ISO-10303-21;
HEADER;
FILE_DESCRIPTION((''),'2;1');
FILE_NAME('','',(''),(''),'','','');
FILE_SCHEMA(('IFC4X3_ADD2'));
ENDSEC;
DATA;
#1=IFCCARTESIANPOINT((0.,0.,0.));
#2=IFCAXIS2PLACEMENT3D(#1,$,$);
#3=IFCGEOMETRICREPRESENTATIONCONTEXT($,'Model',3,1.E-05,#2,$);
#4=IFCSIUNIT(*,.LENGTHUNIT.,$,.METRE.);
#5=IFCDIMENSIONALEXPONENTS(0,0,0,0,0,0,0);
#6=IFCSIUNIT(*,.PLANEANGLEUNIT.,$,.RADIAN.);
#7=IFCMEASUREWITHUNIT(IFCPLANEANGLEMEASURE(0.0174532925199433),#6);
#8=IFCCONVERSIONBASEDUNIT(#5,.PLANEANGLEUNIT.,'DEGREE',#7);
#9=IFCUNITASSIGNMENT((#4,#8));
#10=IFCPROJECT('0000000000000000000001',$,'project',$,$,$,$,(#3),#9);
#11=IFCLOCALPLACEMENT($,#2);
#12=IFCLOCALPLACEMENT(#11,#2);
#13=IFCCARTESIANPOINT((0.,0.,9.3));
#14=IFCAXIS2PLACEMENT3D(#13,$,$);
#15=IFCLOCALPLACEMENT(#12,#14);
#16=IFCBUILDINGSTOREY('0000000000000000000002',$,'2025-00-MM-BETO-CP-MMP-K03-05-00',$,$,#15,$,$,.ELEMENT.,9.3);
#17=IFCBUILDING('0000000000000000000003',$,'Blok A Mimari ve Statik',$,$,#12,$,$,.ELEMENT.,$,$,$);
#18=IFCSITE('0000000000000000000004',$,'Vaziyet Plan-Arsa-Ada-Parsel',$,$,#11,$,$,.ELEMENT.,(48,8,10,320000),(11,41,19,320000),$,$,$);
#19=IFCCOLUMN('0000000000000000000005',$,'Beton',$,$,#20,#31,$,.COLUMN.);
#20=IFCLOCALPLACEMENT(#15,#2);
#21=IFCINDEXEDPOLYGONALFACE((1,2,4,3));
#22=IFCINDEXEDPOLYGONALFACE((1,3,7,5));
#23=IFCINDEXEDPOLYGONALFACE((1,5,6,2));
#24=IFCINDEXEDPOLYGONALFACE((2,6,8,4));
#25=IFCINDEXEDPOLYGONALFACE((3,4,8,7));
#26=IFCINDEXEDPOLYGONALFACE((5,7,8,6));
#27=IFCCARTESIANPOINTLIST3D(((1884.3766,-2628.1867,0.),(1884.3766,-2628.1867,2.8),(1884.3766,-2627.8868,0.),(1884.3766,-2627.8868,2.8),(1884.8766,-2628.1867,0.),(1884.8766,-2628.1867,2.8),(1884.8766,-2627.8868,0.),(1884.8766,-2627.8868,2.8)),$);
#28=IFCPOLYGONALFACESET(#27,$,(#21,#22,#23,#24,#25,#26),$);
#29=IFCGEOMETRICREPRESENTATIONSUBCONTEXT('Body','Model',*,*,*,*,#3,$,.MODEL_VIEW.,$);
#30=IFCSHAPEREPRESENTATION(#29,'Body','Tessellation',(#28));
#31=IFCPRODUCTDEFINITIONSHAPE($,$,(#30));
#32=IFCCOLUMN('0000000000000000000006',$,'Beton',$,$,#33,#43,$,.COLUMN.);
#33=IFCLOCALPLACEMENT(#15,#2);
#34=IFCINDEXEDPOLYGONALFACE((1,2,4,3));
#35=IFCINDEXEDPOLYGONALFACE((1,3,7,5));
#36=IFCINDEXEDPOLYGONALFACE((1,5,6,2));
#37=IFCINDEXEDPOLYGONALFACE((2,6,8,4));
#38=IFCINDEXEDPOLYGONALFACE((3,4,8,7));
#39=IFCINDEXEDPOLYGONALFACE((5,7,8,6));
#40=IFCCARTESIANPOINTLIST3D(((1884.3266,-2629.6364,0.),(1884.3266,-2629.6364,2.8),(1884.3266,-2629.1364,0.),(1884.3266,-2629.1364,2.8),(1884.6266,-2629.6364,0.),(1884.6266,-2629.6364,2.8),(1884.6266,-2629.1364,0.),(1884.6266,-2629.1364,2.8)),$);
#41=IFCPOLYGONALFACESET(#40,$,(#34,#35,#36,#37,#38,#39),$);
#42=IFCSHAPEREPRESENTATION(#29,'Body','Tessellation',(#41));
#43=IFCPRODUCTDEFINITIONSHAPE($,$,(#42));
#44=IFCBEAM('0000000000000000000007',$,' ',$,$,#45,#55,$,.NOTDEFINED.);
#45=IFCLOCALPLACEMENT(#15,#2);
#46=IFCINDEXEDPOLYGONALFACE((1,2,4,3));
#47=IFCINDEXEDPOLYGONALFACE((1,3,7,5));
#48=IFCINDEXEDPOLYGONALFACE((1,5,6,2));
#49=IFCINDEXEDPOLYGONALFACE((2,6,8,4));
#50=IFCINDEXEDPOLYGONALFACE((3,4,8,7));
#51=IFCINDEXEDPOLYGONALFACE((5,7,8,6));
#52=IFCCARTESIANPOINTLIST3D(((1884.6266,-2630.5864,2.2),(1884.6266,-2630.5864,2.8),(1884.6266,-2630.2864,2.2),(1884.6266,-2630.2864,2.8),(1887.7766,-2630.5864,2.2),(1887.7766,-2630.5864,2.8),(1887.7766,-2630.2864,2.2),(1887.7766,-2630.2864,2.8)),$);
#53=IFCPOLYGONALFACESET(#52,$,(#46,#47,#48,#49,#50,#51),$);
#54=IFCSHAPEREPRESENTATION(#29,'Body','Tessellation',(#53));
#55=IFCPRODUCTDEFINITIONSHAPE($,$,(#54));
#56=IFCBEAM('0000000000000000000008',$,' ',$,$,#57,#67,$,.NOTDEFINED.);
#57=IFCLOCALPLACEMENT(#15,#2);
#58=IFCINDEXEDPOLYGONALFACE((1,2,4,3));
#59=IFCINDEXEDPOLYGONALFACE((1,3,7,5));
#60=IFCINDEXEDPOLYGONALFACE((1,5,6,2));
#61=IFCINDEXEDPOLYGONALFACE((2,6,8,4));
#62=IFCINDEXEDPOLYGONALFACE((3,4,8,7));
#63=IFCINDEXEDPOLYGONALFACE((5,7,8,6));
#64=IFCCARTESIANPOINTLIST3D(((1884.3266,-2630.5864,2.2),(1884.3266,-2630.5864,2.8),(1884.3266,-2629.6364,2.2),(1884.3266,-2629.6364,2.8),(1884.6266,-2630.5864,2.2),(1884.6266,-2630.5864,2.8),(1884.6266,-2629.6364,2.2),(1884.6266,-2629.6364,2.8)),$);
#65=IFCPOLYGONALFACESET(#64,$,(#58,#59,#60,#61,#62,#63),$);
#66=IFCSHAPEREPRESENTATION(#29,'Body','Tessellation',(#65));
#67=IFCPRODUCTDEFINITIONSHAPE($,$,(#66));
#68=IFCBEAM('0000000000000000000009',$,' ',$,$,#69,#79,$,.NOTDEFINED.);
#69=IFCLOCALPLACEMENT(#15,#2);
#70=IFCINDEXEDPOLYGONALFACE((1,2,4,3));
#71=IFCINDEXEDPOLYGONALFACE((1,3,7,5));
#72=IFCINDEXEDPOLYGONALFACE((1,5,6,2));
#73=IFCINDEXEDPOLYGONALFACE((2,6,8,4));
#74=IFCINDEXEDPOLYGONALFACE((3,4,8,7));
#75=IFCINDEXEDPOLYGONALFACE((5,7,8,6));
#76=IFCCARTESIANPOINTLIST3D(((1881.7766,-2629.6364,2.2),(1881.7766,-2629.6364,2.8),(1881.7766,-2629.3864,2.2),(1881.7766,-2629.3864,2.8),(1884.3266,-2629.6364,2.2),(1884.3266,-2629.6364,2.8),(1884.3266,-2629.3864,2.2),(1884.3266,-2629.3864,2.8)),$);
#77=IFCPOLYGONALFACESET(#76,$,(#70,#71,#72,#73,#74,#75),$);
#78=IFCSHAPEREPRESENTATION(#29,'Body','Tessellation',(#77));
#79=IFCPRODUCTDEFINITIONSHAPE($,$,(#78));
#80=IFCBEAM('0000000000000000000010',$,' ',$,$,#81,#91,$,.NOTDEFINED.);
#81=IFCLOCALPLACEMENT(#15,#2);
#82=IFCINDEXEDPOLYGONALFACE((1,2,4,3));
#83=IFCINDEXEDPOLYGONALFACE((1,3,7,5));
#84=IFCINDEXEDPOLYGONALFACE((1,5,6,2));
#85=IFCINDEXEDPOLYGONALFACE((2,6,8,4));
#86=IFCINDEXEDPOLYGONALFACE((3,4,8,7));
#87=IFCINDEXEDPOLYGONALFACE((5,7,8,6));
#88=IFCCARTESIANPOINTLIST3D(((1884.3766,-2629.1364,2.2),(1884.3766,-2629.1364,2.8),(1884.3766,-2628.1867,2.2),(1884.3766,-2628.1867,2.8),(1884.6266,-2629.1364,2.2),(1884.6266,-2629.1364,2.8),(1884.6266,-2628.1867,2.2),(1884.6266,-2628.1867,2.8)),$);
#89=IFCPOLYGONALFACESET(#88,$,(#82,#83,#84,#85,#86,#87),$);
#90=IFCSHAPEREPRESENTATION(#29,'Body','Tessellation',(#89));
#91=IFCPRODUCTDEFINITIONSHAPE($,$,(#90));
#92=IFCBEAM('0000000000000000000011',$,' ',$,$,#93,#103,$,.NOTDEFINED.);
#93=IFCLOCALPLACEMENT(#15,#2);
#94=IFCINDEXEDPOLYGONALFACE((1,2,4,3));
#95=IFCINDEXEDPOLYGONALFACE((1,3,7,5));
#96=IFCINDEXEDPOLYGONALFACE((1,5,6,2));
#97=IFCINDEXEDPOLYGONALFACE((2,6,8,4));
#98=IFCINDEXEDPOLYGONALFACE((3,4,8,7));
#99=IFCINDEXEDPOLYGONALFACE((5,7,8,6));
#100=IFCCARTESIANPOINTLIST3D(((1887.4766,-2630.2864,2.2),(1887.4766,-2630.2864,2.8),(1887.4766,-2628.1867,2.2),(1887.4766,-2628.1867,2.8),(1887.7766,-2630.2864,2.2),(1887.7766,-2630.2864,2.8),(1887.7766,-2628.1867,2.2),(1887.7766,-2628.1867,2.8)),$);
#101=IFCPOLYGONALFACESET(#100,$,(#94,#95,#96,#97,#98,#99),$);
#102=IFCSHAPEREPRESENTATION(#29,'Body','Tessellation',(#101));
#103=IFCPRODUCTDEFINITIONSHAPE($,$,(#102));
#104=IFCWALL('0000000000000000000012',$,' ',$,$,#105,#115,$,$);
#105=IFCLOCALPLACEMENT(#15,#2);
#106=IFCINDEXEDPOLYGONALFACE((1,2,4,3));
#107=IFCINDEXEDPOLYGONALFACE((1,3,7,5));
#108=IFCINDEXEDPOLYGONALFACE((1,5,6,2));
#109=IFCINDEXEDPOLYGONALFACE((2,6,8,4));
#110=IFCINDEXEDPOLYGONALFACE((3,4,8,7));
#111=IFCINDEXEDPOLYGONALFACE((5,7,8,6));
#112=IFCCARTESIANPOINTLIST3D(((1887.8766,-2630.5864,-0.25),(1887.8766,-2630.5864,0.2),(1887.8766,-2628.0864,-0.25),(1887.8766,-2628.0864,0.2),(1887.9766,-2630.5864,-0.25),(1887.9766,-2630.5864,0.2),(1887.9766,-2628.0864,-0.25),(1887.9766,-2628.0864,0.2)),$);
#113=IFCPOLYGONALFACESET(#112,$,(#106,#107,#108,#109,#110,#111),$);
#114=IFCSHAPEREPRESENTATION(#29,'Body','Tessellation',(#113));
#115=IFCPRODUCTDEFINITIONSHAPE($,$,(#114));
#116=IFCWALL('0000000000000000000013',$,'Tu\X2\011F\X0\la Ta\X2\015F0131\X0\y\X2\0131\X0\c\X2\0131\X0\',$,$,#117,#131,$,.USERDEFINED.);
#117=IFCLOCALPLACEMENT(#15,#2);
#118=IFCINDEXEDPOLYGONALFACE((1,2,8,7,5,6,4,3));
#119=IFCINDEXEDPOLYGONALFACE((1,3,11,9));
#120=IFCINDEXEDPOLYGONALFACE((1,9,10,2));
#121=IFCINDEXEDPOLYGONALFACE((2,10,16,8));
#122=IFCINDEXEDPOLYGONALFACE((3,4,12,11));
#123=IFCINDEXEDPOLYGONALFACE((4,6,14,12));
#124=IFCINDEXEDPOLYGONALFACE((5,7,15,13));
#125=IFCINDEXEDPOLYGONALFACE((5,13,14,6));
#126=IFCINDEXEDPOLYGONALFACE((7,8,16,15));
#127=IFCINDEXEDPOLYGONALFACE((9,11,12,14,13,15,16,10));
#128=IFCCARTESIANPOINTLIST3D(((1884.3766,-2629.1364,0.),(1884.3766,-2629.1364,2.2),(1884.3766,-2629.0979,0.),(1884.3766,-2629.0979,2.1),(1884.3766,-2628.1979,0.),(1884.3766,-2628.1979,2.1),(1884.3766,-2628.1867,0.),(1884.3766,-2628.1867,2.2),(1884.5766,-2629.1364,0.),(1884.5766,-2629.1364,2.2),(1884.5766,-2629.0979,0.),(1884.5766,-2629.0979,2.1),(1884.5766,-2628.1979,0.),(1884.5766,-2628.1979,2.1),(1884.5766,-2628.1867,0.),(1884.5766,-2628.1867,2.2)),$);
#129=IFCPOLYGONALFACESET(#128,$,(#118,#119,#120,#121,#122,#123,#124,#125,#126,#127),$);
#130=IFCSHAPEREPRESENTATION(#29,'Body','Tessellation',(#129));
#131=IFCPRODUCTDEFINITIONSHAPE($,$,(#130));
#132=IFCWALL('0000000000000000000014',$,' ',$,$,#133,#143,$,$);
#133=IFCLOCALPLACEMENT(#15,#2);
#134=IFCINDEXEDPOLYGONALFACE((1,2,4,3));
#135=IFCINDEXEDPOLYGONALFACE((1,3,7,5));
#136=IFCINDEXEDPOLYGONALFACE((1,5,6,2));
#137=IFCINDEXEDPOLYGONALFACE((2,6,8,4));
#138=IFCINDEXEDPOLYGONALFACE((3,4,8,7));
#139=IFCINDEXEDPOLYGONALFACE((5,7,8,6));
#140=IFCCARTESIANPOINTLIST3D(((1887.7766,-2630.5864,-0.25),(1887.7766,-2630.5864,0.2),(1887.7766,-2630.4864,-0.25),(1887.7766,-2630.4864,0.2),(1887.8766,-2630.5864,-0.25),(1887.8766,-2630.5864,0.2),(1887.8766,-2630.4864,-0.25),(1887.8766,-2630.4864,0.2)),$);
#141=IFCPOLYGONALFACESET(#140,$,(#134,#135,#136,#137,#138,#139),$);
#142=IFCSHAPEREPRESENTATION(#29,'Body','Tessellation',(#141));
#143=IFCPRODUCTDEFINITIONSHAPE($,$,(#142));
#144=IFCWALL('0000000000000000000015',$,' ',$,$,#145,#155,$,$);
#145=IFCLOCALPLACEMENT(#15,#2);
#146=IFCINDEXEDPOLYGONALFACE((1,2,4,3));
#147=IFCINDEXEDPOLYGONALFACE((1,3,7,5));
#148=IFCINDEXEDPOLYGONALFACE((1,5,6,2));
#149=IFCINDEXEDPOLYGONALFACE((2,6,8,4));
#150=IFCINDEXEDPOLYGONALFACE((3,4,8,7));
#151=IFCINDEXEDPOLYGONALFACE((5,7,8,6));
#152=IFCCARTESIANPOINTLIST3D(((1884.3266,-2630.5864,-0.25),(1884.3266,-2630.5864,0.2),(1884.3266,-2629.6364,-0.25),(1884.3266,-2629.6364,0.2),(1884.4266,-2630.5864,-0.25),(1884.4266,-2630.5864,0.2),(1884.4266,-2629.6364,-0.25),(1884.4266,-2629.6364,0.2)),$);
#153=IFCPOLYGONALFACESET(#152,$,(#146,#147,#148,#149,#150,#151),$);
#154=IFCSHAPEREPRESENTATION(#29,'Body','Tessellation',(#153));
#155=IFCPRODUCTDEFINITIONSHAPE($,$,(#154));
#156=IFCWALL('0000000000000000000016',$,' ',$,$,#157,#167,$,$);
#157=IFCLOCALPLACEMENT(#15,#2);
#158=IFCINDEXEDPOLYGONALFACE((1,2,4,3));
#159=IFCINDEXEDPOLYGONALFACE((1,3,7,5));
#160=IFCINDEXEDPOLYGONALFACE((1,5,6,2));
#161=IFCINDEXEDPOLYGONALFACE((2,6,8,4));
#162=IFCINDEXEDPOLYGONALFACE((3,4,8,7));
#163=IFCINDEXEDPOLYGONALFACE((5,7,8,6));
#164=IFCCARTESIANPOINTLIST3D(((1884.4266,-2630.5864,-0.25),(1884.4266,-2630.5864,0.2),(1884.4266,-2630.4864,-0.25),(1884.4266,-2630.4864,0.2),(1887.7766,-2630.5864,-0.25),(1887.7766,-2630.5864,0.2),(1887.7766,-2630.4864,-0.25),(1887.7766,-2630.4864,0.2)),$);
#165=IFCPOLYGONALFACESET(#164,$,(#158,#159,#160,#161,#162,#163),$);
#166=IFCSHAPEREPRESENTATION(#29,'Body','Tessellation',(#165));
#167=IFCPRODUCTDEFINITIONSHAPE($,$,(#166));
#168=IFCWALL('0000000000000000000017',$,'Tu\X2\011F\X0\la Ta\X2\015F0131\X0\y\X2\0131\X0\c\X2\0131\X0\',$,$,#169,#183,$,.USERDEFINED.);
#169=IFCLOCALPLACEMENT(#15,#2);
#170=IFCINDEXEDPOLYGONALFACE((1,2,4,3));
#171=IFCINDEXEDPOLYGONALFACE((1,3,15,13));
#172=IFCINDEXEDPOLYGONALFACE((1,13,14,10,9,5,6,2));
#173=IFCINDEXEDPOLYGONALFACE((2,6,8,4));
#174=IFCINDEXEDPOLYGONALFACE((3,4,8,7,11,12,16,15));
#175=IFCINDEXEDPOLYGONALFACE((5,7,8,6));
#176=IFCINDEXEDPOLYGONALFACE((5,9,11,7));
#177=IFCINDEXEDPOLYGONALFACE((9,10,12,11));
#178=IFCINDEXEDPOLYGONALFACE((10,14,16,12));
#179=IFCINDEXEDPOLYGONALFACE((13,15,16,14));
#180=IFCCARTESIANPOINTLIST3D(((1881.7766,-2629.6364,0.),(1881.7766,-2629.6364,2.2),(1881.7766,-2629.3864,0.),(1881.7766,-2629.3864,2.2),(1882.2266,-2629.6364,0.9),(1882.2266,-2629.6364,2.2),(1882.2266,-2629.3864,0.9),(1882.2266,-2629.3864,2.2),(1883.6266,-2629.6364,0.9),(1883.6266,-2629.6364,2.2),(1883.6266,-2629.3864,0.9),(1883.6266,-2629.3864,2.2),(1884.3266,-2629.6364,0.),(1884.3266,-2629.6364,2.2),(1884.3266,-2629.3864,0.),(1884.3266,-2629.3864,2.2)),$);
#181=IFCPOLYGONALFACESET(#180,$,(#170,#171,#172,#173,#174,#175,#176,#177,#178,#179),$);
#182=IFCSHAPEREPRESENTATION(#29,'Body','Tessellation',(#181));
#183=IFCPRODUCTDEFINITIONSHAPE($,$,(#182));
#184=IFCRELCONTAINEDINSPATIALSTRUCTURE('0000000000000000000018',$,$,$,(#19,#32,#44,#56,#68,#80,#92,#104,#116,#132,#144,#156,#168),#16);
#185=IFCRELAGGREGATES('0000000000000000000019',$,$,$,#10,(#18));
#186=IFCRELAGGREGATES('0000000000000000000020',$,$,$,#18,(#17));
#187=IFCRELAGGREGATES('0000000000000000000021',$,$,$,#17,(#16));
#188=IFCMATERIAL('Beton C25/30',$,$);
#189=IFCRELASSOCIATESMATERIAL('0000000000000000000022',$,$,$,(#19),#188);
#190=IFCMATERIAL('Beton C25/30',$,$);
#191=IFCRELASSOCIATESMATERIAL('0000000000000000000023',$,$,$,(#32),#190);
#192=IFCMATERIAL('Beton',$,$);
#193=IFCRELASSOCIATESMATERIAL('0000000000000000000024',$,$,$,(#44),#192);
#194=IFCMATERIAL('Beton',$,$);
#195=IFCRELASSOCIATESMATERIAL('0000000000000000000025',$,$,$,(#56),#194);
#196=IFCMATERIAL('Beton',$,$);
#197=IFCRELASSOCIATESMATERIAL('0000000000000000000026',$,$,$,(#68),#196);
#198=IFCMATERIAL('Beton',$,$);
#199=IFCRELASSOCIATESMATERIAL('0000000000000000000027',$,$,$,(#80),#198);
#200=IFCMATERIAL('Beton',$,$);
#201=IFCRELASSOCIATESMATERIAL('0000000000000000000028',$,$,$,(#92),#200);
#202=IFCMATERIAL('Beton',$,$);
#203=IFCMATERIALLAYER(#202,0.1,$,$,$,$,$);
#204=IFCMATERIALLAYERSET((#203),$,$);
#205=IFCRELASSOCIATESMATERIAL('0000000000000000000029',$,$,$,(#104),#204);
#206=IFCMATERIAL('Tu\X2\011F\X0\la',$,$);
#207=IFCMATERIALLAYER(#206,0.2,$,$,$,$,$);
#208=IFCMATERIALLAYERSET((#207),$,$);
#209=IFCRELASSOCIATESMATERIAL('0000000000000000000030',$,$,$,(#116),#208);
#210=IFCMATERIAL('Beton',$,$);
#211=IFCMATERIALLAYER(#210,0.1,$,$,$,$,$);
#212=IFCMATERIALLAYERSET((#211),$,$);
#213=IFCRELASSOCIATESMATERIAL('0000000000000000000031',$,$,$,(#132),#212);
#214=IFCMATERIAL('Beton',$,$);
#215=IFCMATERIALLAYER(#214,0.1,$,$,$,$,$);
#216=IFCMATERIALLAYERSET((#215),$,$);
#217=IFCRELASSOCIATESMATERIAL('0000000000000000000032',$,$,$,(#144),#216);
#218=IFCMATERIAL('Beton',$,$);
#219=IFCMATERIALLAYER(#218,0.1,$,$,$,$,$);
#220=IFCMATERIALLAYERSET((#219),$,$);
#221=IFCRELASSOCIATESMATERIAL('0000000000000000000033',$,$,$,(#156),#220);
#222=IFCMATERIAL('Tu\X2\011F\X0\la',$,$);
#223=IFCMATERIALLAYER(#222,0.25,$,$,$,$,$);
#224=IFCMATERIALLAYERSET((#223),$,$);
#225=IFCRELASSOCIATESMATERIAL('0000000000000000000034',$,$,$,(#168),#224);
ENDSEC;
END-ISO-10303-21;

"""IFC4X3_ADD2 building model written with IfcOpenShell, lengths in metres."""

from ifc_helpers import new_model, entity, si_unit, converted_unit, frame, frame_2d, origin, origin_with_axes, place, context, subcontext, project, spatial, polyline, rectangle, outline, extrude, material, layer, layer_set, layer_usage, element, save


model = new_model("IFC4X3_ADD2")

# Units and contexts
model_context = context("Model", 3, precision=1e-05, world=origin())
body_context = subcontext(model_context, "Body", "Model", "MODEL_VIEW")
ifc_project = project(units=[si_unit("LENGTHUNIT", "METRE"), converted_unit("PLANEANGLEUNIT", "DEGREE", entity("IfcPlaneAngleMeasure", 0.0174532925199433), si_unit("PLANEANGLEUNIT", "RADIAN"), dimensions=[0, 0, 0, 0, 0, 0, 0])], contexts=[model_context])

# Site, building, storey
site_placement = place(None, origin())
site = spatial("IfcSite", under=ifc_project, at=site_placement, Name="Vaziyet Plan-Arsa-Ada-Parsel", CompositionType="ELEMENT", RefLatitude=(48, 8, 10, 320000), RefLongitude=(11, 41, 19, 320000))
building_placement = place(site_placement, origin())
building = spatial("IfcBuilding", under=site, at=building_placement, Name="Blok A Mimari ve Statik", CompositionType="ELEMENT")
storey_placement = place(building_placement, frame((0.0, 0.0, 9.3)))
storey = spatial("IfcBuildingStorey", under=building, at=storey_placement, Name="2025-00-MM-BETO-CP-MMP-K03-05-00", CompositionType="ELEMENT", Elevation=9.3)

# Columns
ifc_material_1 = material(Name="Beton C25/30")
column_1_placement = place(storey_placement, frame((1884.3766, -2628.1867, 0.0)))
element("IfcColumn", 1, at=column_1_placement, inside=storey, material=ifc_material_1, Name="Beton", PredefinedType="COLUMN", context=body_context, shape_type="SweptSolid", body=[
    extrude(outline(polyline([(0.0, 0.3), (0.0, 0.0), (0.5, 0.0), (0.5, 0.3), (0.0, 0.3)])), origin_with_axes(), (0.0, 0.0, 1.0), 2.8),
])
ifc_material_2 = material(Name="Beton C25/30")
column_2_placement = place(storey_placement, frame((1884.3266, -2629.6364, 0.0)))
element("IfcColumn", 2, at=column_2_placement, inside=storey, material=ifc_material_2, Name="Beton", PredefinedType="COLUMN", context=body_context, shape_type="SweptSolid", body=[
    extrude(outline(polyline([(0.0, 0.5), (0.0, 0.0), (0.3, 0.0), (0.3, 0.5), (0.0, 0.5)])), origin_with_axes(), (0.0, 0.0, 1.0), 2.8),
])

# Beams
ifc_material_3 = material(Name="Beton")
beam_1_placement = place(storey_placement, frame((1884.6266, -2630.5864, 2.2)))
element("IfcBeam", 3, at=beam_1_placement, inside=storey, material=ifc_material_3, Name=" ", PredefinedType="NOTDEFINED", context=body_context, shape_type="SweptSolid", body=[
    extrude(rectangle(XDim=0.3, YDim=0.6, at=frame_2d((0.15, 0.3), x_axis=(1.0, 0.0))), frame((0.0, 0.0, 0.0), z_axis=(1.0, 0.0, 0.0), x_axis=(0.0, 1.0, 0.0)), (0.0, 0.0, 1.0), 3.15),
])
ifc_material_4 = material(Name="Beton")
beam_2_placement = place(storey_placement, frame((1884.3266, -2629.6364, 2.2), z_axis=(0.0, 0.0, 1.0), x_axis=(0.0, -1.0, 0.0)))
element("IfcBeam", 4, at=beam_2_placement, inside=storey, material=ifc_material_4, Name=" ", PredefinedType="NOTDEFINED", context=body_context, shape_type="SweptSolid", body=[
    extrude(rectangle(XDim=0.3, YDim=0.6, at=frame_2d((0.15, 0.3), x_axis=(1.0, 0.0))), frame((0.0, 0.0, 0.0), z_axis=(1.0, 0.0, 0.0), x_axis=(0.0, 1.0, 0.0)), (0.0, 0.0, 1.0), 0.95),
])
ifc_material_5 = material(Name="Beton")
beam_3_placement = place(storey_placement, frame((1881.7766, -2629.6364, 2.2), z_axis=(0.0, 0.0, 1.0), x_axis=(1.0, 0.0, 0.0)))
element("IfcBeam", 5, at=beam_3_placement, inside=storey, material=ifc_material_5, Name=" ", PredefinedType="NOTDEFINED", context=body_context, shape_type="SweptSolid", body=[
    extrude(rectangle(XDim=0.25, YDim=0.6, at=frame_2d((0.125, 0.3), x_axis=(1.0, 0.0))), frame((0.0, 0.0, 0.0), z_axis=(1.0, 0.0, 0.0), x_axis=(0.0, 1.0, 0.0)), (0.0, 0.0, 1.0), 2.55),
])
ifc_material_6 = material(Name="Beton")
beam_4_placement = place(storey_placement, frame((1884.6266, -2629.1364, 2.2), z_axis=(0.0, 0.0, 1.0), x_axis=(0.000003, 1.0, 0.0)))
element("IfcBeam", 6, at=beam_4_placement, inside=storey, material=ifc_material_6, Name=" ", PredefinedType="NOTDEFINED", context=body_context, shape_type="SweptSolid", body=[
    extrude(rectangle(XDim=0.25, YDim=0.6, at=frame_2d((0.125, 0.3), x_axis=(1.0, 0.0))), frame((0.0, 0.0, 0.0), z_axis=(1.0, 0.0, 0.0), x_axis=(0.0, 1.0, 0.0)), (0.0, 0.0, 1.0), 0.9497),
])
ifc_material_7 = material(Name="Beton")
beam_5_placement = place(storey_placement, frame((1887.7766, -2630.2864, 2.2), z_axis=(0.0, 0.0, 1.0), x_axis=(0.0, 1.0, 0.0)))
element("IfcBeam", 7, at=beam_5_placement, inside=storey, material=ifc_material_7, Name=" ", PredefinedType="NOTDEFINED", context=body_context, shape_type="SweptSolid", body=[
    extrude(rectangle(XDim=0.3, YDim=0.6, at=frame_2d((0.15, 0.3), x_axis=(1.0, 0.0))), frame((0.0, 0.0, 0.0), z_axis=(1.0, 0.0, 0.0), x_axis=(0.0, 1.0, 0.0)), (0.0, 0.0, 1.0), 2.0997),
])

# Wall
ifc_material_8 = material(Name="Beton")
ifc_layer_1 = layer(ifc_material_8, 0.1)
ifc_layer_set_1 = layer_set([ifc_layer_1])
ifc_layer_usage_1 = layer_usage(ifc_layer_set_1, "AXIS2", "POSITIVE", 0.0)
wall_1_placement = place(storey_placement, frame((1887.9766, -2630.5864, -0.25), z_axis=(0.0, 0.0, 1.0), x_axis=(0.0, 1.0, 0.0)))
element("IfcWall", 8, at=wall_1_placement, inside=storey, material=ifc_layer_usage_1, Name=" ", context=body_context, shape_type="SweptSolid", body=[
    extrude(rectangle(XDim=2.5, YDim=0.1, at=frame_2d((1.25, 0.05), x_axis=(1.0, 0.0))), origin_with_axes(), (0.0, 0.0, 1.0), 0.45),
])

# Wall, opening
ifc_material_9 = material(Name="Tuğla")
ifc_layer_2 = layer(ifc_material_9, 0.2)
ifc_layer_set_2 = layer_set([ifc_layer_2])
ifc_layer_usage_2 = layer_usage(ifc_layer_set_2, "AXIS2", "POSITIVE", 0.0)
wall_2_placement = place(storey_placement, frame((1884.3766, -2628.1867, 0.0), z_axis=(0.0, 0.0, 1.0), x_axis=(0.0, -1.0, 0.0)))
wall_2 = element("IfcWall", 9, at=wall_2_placement, inside=storey, material=ifc_layer_usage_2, Name="Tuğla Taşıyıcı", PredefinedType="USERDEFINED", context=body_context, shape_type="SweptSolid", body=[
    extrude(rectangle(XDim=0.9497, YDim=0.2, at=frame_2d((0.4748, 0.1), x_axis=(1.0, 0.0))), origin_with_axes(), (0.0, 0.0, 1.0), 2.2),
])
opening_1_placement = place(wall_2_placement, frame((0.0111, 0.0, 0.0), z_axis=(0.0, 1.0, 0.0), x_axis=(0.0, 0.0, 1.0)))
element("IfcOpeningElement", 10, at=opening_1_placement, cuts=wall_2, PredefinedType="OPENING", context=body_context, shape_type="SweptSolid", body=[
    extrude(outline(polyline([(2.1, 0.9), (2.1, 0.0), (0.0, 0.0), (0.0, 0.9), (2.1, 0.9)])), origin_with_axes(), (0.0, 0.0, 1.0), 0.2),
])

# Walls
ifc_material_10 = material(Name="Beton")
ifc_layer_3 = layer(ifc_material_10, 0.1)
ifc_layer_set_3 = layer_set([ifc_layer_3])
ifc_layer_usage_3 = layer_usage(ifc_layer_set_3, "AXIS2", "POSITIVE", 0.0)
wall_3_placement = place(storey_placement, frame((1887.7766, -2630.5864, -0.25)))
element("IfcWall", 11, at=wall_3_placement, inside=storey, material=ifc_layer_usage_3, Name=" ", context=body_context, shape_type="SweptSolid", body=[
    extrude(rectangle(XDim=0.1, YDim=0.1, at=frame_2d((0.05, 0.05), x_axis=(1.0, 0.0))), origin_with_axes(), (0.0, 0.0, 1.0), 0.45),
])
ifc_material_11 = material(Name="Beton")
ifc_layer_4 = layer(ifc_material_11, 0.1)
ifc_layer_set_4 = layer_set([ifc_layer_4])
ifc_layer_usage_4 = layer_usage(ifc_layer_set_4, "AXIS2", "POSITIVE", 0.0)
wall_4_placement = place(storey_placement, frame((1884.3266, -2629.6364, -0.25), z_axis=(0.0, 0.0, 1.0), x_axis=(0.0, -1.0, 0.0)))
element("IfcWall", 12, at=wall_4_placement, inside=storey, material=ifc_layer_usage_4, Name=" ", context=body_context, shape_type="SweptSolid", body=[
    extrude(rectangle(XDim=0.95, YDim=0.1, at=frame_2d((0.475, 0.05), x_axis=(1.0, 0.0))), origin_with_axes(), (0.0, 0.0, 1.0), 0.45),
])
ifc_material_12 = material(Name="Beton")
ifc_layer_5 = layer(ifc_material_12, 0.1)
ifc_layer_set_5 = layer_set([ifc_layer_5])
ifc_layer_usage_5 = layer_usage(ifc_layer_set_5, "AXIS2", "POSITIVE", 0.0)
wall_5_placement = place(storey_placement, frame((1884.4266, -2630.5864, -0.25)))
element("IfcWall", 13, at=wall_5_placement, inside=storey, material=ifc_layer_usage_5, Name=" ", context=body_context, shape_type="SweptSolid", body=[
    extrude(rectangle(XDim=3.35, YDim=0.1, at=frame_2d((1.675, 0.05), x_axis=(1.0, 0.0))), origin_with_axes(), (0.0, 0.0, 1.0), 0.45),
])

# Wall, opening
ifc_material_13 = material(Name="Tuğla")
ifc_layer_6 = layer(ifc_material_13, 0.25)
ifc_layer_set_6 = layer_set([ifc_layer_6])
ifc_layer_usage_6 = layer_usage(ifc_layer_set_6, "AXIS2", "POSITIVE", 0.0)
wall_6_placement = place(storey_placement, frame((1881.7766, -2629.6364, 0.0), z_axis=(0.0, 0.0, 1.0), x_axis=(1.0, 0.0, 0.0)))
wall_6 = element("IfcWall", 14, at=wall_6_placement, inside=storey, material=ifc_layer_usage_6, Name="Tuğla Taşıyıcı", PredefinedType="USERDEFINED", context=body_context, shape_type="SweptSolid", body=[
    extrude(rectangle(XDim=2.55, YDim=0.25, at=frame_2d((1.275, 0.125), x_axis=(1.0, 0.0))), origin_with_axes(), (0.0, 0.0, 1.0), 2.2),
])
opening_2_placement = place(wall_6_placement, frame((0.45, 0.0, 0.9), z_axis=(0.0, 1.0, 0.0), x_axis=(0.0, 0.0, 1.0)))
element("IfcOpeningElement", 15, at=opening_2_placement, cuts=wall_6, PredefinedType="OPENING", context=body_context, shape_type="SweptSolid", body=[
    extrude(outline(polyline([(1.35, 1.4), (1.35, 0.0), (0.0, 0.0), (0.0, 1.4), (1.35, 1.4)])), origin_with_axes(), (0.0, 0.0, 1.0), 0.25),
])

save(model, "model.ifc")
